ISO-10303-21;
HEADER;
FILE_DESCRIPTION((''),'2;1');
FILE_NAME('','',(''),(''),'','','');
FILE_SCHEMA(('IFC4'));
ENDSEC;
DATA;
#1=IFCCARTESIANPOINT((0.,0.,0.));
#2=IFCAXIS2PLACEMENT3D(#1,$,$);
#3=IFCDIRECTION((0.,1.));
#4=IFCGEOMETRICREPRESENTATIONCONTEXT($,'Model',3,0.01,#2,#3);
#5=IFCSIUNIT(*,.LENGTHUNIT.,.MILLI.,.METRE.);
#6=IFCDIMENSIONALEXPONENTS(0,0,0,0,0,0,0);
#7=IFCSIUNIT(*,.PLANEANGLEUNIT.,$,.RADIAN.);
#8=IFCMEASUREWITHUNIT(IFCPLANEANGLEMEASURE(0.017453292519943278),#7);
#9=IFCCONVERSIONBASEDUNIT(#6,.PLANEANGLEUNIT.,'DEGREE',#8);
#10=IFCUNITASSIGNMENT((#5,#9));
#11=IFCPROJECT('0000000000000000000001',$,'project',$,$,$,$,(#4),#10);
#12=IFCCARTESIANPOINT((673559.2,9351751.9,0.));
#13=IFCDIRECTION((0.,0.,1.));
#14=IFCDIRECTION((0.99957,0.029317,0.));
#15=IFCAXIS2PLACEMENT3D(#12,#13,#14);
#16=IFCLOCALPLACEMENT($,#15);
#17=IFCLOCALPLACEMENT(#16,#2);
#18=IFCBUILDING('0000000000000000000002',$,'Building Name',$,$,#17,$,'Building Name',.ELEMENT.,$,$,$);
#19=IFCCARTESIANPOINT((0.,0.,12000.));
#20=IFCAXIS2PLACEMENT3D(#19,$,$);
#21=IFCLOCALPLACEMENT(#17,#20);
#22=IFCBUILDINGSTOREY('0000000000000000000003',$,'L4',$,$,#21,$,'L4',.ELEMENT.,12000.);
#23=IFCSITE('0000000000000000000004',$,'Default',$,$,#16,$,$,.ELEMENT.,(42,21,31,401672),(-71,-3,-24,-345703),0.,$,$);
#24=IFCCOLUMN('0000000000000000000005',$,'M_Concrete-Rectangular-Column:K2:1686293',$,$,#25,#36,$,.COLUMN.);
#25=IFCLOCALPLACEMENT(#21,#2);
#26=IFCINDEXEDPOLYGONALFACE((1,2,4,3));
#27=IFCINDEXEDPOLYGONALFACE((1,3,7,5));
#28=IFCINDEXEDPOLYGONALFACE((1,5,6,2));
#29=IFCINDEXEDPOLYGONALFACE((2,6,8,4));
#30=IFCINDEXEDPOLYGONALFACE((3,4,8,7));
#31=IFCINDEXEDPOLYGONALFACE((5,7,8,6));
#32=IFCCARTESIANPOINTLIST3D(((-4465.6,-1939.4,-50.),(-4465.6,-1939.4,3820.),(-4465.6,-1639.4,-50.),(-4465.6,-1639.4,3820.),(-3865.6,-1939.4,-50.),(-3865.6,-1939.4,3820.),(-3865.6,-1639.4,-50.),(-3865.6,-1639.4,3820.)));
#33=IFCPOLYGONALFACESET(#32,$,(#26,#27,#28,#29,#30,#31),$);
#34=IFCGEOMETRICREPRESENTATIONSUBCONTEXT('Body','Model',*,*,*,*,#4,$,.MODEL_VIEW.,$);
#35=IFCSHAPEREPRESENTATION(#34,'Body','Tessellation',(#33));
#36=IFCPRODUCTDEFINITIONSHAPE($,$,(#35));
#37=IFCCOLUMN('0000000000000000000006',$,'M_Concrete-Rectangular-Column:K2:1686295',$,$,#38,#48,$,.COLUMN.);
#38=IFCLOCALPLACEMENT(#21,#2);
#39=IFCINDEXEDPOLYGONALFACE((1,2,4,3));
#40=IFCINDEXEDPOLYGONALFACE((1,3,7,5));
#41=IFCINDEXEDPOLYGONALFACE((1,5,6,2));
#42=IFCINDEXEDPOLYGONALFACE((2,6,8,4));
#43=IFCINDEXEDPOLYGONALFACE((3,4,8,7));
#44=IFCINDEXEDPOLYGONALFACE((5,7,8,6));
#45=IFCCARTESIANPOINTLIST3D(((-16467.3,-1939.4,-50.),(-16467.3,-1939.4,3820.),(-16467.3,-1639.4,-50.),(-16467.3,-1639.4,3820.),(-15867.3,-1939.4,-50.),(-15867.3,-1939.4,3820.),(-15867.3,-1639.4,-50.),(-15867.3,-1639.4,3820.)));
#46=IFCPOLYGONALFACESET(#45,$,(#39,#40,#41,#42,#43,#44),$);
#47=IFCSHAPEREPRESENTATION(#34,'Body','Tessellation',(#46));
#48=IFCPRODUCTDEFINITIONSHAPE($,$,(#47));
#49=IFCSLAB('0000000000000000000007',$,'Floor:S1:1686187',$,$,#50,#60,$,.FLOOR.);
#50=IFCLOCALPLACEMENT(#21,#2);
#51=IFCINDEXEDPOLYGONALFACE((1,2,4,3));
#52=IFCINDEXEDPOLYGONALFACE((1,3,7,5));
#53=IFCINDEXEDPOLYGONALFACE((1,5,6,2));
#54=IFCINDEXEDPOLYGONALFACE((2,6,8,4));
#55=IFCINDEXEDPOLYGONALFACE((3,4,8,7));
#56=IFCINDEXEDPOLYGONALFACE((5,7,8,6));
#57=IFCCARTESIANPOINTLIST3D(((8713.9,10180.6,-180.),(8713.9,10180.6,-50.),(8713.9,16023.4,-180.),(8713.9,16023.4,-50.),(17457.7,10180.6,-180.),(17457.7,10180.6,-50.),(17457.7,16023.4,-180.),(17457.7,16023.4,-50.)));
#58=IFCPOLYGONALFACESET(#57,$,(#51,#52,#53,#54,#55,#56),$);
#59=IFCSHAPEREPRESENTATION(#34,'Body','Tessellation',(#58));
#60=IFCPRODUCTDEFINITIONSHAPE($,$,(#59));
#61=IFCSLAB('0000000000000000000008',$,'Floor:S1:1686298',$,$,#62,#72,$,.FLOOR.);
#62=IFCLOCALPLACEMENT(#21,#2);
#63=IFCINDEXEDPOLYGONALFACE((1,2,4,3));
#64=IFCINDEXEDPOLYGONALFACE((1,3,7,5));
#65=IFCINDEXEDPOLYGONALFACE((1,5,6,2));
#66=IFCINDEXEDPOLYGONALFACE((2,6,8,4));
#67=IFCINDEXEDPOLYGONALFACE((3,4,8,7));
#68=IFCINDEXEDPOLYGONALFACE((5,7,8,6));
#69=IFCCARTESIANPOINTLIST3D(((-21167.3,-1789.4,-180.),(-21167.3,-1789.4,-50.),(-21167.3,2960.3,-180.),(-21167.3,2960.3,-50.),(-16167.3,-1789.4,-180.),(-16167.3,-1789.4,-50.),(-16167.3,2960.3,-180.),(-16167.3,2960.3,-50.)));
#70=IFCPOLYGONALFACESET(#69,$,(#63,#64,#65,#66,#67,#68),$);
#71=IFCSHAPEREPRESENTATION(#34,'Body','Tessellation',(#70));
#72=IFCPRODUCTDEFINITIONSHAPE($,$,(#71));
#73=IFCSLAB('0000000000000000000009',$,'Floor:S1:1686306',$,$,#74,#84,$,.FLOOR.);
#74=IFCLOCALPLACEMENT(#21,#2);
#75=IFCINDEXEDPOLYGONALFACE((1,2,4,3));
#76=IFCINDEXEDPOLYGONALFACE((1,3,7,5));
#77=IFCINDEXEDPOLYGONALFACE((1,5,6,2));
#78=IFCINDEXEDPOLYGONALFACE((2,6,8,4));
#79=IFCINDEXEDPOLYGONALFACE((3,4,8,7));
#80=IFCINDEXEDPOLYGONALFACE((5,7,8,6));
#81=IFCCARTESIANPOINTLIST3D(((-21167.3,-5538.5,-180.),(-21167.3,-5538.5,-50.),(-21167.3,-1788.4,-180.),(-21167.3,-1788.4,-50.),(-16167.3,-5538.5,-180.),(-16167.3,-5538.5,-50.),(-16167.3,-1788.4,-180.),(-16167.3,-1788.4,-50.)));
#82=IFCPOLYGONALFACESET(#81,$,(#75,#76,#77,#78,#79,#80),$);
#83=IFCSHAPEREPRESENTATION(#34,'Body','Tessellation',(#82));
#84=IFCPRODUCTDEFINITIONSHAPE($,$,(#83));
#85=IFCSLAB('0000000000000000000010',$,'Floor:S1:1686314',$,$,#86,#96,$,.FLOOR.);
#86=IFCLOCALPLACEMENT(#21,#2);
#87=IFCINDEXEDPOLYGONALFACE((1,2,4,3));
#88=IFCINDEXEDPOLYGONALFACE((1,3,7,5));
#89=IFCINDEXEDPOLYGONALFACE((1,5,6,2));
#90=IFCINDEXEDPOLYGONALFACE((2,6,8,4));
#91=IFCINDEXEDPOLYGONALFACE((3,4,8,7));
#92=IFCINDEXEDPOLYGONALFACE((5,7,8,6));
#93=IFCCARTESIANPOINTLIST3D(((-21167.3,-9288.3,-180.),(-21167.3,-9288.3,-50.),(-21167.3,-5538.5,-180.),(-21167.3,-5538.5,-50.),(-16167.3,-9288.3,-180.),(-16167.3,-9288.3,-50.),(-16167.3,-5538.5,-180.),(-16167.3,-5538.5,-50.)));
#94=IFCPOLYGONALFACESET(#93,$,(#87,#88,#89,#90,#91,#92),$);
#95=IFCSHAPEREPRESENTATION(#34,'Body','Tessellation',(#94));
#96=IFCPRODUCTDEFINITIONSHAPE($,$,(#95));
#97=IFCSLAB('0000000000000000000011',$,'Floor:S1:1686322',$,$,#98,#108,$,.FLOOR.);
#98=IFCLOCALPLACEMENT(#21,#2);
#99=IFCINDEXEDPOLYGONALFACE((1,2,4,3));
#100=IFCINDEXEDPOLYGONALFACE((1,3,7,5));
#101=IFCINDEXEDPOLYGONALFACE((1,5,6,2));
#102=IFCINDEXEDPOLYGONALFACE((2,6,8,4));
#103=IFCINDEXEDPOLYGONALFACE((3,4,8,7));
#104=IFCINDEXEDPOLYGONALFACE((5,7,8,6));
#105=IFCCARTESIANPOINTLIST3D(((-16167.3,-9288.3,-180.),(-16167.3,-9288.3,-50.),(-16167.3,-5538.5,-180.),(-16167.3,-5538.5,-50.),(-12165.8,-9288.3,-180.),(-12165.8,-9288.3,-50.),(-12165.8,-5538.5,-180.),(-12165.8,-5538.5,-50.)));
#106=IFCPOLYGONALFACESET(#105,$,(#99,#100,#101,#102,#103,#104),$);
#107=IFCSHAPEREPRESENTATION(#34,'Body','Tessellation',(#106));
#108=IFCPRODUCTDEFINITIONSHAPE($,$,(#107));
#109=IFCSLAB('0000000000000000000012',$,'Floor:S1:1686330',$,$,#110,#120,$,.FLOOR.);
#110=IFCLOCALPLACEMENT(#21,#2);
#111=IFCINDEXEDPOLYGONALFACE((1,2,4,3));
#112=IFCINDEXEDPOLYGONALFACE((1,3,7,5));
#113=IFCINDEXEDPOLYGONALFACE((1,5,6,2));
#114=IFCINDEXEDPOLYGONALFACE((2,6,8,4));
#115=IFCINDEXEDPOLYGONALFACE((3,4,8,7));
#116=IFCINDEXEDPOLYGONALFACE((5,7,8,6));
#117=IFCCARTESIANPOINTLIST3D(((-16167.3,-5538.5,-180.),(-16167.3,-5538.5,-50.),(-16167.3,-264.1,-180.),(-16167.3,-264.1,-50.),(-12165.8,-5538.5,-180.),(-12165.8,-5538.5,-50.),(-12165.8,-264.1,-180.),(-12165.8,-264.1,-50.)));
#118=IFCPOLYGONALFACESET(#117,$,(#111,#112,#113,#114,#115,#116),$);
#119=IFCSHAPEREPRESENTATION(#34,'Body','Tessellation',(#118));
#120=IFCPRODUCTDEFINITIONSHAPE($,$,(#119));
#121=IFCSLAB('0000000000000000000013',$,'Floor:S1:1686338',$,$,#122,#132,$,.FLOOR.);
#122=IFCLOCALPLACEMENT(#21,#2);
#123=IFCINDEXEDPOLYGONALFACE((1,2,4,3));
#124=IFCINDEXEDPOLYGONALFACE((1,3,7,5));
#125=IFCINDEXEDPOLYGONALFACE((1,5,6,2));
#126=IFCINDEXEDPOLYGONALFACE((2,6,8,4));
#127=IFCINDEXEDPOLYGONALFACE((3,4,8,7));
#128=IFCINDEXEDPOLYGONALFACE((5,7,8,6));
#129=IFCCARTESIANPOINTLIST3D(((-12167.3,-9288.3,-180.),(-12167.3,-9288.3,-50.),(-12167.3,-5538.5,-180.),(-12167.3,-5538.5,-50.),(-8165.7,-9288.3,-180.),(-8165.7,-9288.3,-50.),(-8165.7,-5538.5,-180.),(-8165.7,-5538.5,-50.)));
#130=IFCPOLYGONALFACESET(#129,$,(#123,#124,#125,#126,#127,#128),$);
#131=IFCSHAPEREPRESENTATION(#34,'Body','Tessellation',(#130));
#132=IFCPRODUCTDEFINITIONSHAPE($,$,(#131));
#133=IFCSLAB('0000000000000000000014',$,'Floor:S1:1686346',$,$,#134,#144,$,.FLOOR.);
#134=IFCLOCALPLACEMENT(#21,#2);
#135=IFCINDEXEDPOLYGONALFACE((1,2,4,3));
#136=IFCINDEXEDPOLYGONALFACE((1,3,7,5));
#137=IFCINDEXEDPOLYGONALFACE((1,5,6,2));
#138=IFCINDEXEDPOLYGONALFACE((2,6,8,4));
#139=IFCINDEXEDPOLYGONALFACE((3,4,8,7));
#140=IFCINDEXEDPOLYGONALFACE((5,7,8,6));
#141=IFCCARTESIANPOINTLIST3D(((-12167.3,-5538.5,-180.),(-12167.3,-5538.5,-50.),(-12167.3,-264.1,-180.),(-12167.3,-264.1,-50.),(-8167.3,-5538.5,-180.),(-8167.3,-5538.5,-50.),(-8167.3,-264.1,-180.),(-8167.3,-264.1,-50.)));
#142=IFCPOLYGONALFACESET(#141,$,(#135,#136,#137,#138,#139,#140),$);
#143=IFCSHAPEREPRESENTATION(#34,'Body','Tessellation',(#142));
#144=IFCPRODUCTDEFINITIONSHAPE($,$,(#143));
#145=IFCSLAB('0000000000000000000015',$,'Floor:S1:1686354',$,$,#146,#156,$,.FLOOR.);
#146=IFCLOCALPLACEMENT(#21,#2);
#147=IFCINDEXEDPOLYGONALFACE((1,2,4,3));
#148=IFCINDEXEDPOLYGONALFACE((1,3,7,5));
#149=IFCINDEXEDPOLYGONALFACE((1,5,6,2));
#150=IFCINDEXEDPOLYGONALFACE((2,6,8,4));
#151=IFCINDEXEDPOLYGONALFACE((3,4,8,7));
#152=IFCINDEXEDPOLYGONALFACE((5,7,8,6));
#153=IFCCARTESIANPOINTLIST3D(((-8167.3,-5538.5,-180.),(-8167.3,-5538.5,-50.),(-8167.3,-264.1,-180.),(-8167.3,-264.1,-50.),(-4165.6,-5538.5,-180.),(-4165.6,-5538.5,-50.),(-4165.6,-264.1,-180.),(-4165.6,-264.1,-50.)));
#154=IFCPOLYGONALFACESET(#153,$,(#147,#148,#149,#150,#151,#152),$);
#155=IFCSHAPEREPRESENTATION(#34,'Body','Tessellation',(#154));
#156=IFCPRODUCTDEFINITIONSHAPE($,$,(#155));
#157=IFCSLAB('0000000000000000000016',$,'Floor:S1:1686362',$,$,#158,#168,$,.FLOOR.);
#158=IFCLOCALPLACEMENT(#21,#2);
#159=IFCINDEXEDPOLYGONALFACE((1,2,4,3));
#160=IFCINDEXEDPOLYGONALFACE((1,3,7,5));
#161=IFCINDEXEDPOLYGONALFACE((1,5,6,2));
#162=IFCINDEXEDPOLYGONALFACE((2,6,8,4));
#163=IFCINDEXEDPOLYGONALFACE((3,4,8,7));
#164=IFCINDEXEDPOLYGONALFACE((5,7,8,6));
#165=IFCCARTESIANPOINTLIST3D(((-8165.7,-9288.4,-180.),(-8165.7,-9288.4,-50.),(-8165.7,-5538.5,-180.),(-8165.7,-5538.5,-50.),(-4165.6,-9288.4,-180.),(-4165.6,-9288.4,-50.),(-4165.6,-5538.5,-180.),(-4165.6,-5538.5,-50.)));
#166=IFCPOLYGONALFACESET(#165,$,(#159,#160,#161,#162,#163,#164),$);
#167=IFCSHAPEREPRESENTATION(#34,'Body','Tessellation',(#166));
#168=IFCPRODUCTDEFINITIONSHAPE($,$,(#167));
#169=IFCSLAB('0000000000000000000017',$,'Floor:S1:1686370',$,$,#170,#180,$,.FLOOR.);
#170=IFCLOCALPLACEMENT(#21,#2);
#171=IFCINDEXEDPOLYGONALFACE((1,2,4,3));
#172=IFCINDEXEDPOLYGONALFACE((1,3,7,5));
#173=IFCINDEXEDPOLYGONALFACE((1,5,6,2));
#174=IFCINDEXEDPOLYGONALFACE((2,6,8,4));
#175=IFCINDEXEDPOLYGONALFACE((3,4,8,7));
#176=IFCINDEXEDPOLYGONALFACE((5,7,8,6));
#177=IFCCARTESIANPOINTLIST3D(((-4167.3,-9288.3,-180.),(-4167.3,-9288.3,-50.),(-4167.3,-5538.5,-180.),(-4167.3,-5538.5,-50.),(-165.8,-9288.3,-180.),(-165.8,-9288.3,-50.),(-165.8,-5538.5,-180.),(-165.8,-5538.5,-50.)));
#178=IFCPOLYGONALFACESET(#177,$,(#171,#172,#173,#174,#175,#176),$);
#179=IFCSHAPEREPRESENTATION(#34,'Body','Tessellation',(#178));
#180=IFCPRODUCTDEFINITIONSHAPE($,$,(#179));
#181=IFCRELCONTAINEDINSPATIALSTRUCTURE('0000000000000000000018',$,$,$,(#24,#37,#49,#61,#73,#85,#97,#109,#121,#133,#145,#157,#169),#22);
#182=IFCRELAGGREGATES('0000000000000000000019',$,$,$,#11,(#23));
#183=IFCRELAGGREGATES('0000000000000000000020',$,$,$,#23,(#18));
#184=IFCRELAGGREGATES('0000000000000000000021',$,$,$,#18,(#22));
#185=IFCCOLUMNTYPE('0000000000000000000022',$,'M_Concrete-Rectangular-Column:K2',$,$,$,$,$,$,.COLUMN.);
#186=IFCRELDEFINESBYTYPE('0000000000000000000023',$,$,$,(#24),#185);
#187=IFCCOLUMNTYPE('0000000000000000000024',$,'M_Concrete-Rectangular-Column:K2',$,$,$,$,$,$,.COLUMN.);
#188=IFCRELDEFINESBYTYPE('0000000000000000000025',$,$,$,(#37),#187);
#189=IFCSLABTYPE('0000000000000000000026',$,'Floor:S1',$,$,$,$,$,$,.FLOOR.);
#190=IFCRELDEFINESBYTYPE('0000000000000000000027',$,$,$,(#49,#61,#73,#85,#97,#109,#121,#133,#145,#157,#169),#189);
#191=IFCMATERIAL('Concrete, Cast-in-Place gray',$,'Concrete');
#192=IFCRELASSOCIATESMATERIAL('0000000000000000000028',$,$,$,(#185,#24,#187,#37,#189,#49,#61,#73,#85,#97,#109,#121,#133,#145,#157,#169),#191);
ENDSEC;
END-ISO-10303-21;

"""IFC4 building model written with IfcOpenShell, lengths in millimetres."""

from ifc_helpers import new_model, entity, si_unit, converted_unit, direction, frame, origin, place, context, subcontext, project, spatial, indexed_curve, outline, extrude, source, transform, mapped, material, type_object, type_shapes, element, save


model = new_model("IFC4")

# Units and contexts
model_context = context("Model", 3, precision=0.01, world=origin(), true_north=direction((0.0, 1.0)))
body_context = subcontext(model_context, "Body", "Model", "MODEL_VIEW")
ifc_project = project(units=[si_unit("LENGTHUNIT", "METRE", prefix="MILLI"), converted_unit("PLANEANGLEUNIT", "DEGREE", entity("IfcPlaneAngleMeasure", 0.017453292519943278), si_unit("PLANEANGLEUNIT", "RADIAN"), dimensions=[0, 0, 0, 0, 0, 0, 0])], contexts=[model_context])

# Site, building, storey
site_placement = place(None, frame((673559.2, 9351751.9, 0.0), z_axis=(0.0, 0.0, 1.0), x_axis=(0.99957, 0.029317, 0.0)))
site = spatial("IfcSite", under=ifc_project, at=site_placement, Name="Default", CompositionType="ELEMENT", RefLatitude=(42, 21, 31, 401672), RefLongitude=(-71, -3, -24, -345703), RefElevation=0.0)
building_placement = place(site_placement, origin())
building = spatial("IfcBuilding", under=site, at=building_placement, Name="Building Name", LongName="Building Name", CompositionType="ELEMENT")
storey_placement = place(building_placement, frame((0.0, 0.0, 12000.0)))
storey = spatial("IfcBuildingStorey", under=building, at=storey_placement, Name="L4", LongName="L4", CompositionType="ELEMENT", Elevation=12000.0)

# Columns
ifc_material = material(Name="Concrete, Cast-in-Place gray", Category="Concrete")
column_type_1 = type_object("IfcColumnType", Name="M_Concrete-Rectangular-Column:K2", PredefinedType="COLUMN", material=ifc_material)
shared_shape_1 = source(origin(), body_context, "Body", "SweptSolid", [
    extrude(outline(indexed_curve([(-150.0, -300.0), (150.0, -300.0), (150.0, 300.0), (-150.0, 300.0), (-150.0, -300.0)], self_intersect=False)), frame((-4165.6, -1789.4, 11950.0), z_axis=(0.0, 0.0, 1.0), x_axis=(0.0, -1.0, 0.0)), (0.0, 0.0, 1.0), 3870.0),
])
type_shapes(column_type_1, [shared_shape_1])
column_1_placement = place(storey_placement, frame((0.0, 0.0, -12000.0)))
element("IfcColumn", 1, at=column_1_placement, inside=storey, type_object=column_type_1, material=ifc_material, Name="M_Concrete-Rectangular-Column:K2:1686293", PredefinedType="COLUMN", context=body_context, shape_type="MappedRepresentation", body=[
    mapped(shared_shape_1, transform((0.0, 0.0, 0.0), scale=1.0)),
])
column_type_2 = type_object("IfcColumnType", Name="M_Concrete-Rectangular-Column:K2", PredefinedType="COLUMN", material=ifc_material)
shared_shape_2 = source(origin(), body_context, "Body", "SweptSolid", [
    extrude(outline(indexed_curve([(-150.0, -300.0), (150.0, -300.0), (150.0, 300.0), (-150.0, 300.0), (-150.0, -300.0)], self_intersect=False)), frame((-16167.3, -1789.4, 11950.0), z_axis=(0.0, 0.0, 1.0), x_axis=(0.0, -1.0, 0.0)), (0.0, 0.0, 1.0), 3870.0),
])
type_shapes(column_type_2, [shared_shape_2])
column_2_placement = place(storey_placement, frame((0.0, 0.0, -12000.0)))
element("IfcColumn", 2, at=column_2_placement, inside=storey, type_object=column_type_2, material=ifc_material, Name="M_Concrete-Rectangular-Column:K2:1686295", PredefinedType="COLUMN", context=body_context, shape_type="MappedRepresentation", body=[
    mapped(shared_shape_2, transform((0.0, 0.0, 0.0), scale=1.0)),
])

# Slabs
slab_type_1 = type_object("IfcSlabType", Name="Floor:S1", PredefinedType="FLOOR", material=ifc_material)
slab_1_placement = place(storey_placement, origin())
element("IfcSlab", 3, at=slab_1_placement, inside=storey, type_object=slab_type_1, material=ifc_material, Name="Floor:S1:1686187", PredefinedType="FLOOR", context=body_context, shape_type="SweptSolid", body=[
    extrude(outline(indexed_curve([(-2921.4, -4371.9), (2921.4, -4371.9), (2921.4, 4371.9), (-2921.4, 4371.9), (-2921.4, -4371.9)], self_intersect=False)), frame((13085.8, 13102.0, -50.0), z_axis=(0.0, 0.0, -1.0), x_axis=(0.0, 1.0, 0.0)), (0.0, 0.0, 1.0), 130.0),
])
slab_2_placement = place(storey_placement, origin())
element("IfcSlab", 4, at=slab_2_placement, inside=storey, type_object=slab_type_1, material=ifc_material, Name="Floor:S1:1686298", PredefinedType="FLOOR", context=body_context, shape_type="SweptSolid", body=[
    extrude(outline(indexed_curve([(-2374.9, -2500.0), (2374.9, -2500.0), (2374.9, 2500.0), (-2374.9, 2500.0), (-2374.9, -2500.0)], self_intersect=False)), frame((-18667.3, 585.4, -50.0), z_axis=(0.0, 0.0, -1.0), x_axis=(0.0, 1.0, 0.0)), (0.0, 0.0, 1.0), 130.0),
])
slab_3_placement = place(storey_placement, origin())
element("IfcSlab", 5, at=slab_3_placement, inside=storey, type_object=slab_type_1, material=ifc_material, Name="Floor:S1:1686306", PredefinedType="FLOOR", context=body_context, shape_type="SweptSolid", body=[
    extrude(outline(indexed_curve([(-1875.1, -2500.0), (1875.1, -2500.0), (1875.1, 2500.0), (-1875.1, 2500.0), (-1875.1, -2500.0)], self_intersect=False)), frame((-18667.3, -3663.5, -50.0), z_axis=(0.0, 0.0, -1.0), x_axis=(0.0, 1.0, 0.0)), (0.0, 0.0, 1.0), 130.0),
])
slab_4_placement = place(storey_placement, origin())
element("IfcSlab", 6, at=slab_4_placement, inside=storey, type_object=slab_type_1, material=ifc_material, Name="Floor:S1:1686314", PredefinedType="FLOOR", context=body_context, shape_type="SweptSolid", body=[
    extrude(outline(indexed_curve([(-1874.9, -2500.0), (1874.9, -2500.0), (1874.9, 2500.0), (-1874.9, 2500.0), (-1874.9, -2500.0)], self_intersect=False)), frame((-18667.3, -7413.4, -50.0), z_axis=(0.0, 0.0, -1.0), x_axis=(0.0, 1.0, 0.0)), (0.0, 0.0, 1.0), 130.0),
])
slab_5_placement = place(storey_placement, origin())
element("IfcSlab", 7, at=slab_5_placement, inside=storey, type_object=slab_type_1, material=ifc_material, Name="Floor:S1:1686322", PredefinedType="FLOOR", context=body_context, shape_type="SweptSolid", body=[
    extrude(outline(indexed_curve([(-1874.9, -2000.8), (1874.9, -2000.8), (1874.9, 2000.8), (-1874.9, 2000.8), (-1874.9, -2000.8)], self_intersect=False)), frame((-14166.6, -7413.4, -50.0), z_axis=(0.0, 0.0, -1.0), x_axis=(0.0, 1.0, 0.0)), (0.0, 0.0, 1.0), 130.0),
])
slab_6_placement = place(storey_placement, origin())
element("IfcSlab", 8, at=slab_6_placement, inside=storey, type_object=slab_type_1, material=ifc_material, Name="Floor:S1:1686330", PredefinedType="FLOOR", context=body_context, shape_type="SweptSolid", body=[
    extrude(outline(indexed_curve([(-2637.2, -2000.8), (2637.2, -2000.8), (2637.2, 2000.8), (-2637.2, 2000.8), (-2637.2, -2000.8)], self_intersect=False)), frame((-14166.6, -2901.3, -50.0), z_axis=(0.0, 0.0, -1.0), x_axis=(0.0, 1.0, 0.0)), (0.0, 0.0, 1.0), 130.0),
])
slab_7_placement = place(storey_placement, origin())
element("IfcSlab", 9, at=slab_7_placement, inside=storey, type_object=slab_type_1, material=ifc_material, Name="Floor:S1:1686338", PredefinedType="FLOOR", context=body_context, shape_type="SweptSolid", body=[
    extrude(outline(indexed_curve([(-1874.9, -2000.8), (1874.9, -2000.8), (1874.9, 2000.8), (-1874.9, 2000.8), (-1874.9, -2000.8)], self_intersect=False)), frame((-10166.5, -7413.4, -50.0), z_axis=(0.0, 0.0, -1.0), x_axis=(0.0, 1.0, 0.0)), (0.0, 0.0, 1.0), 130.0),
])
slab_8_placement = place(storey_placement, origin())
element("IfcSlab", 10, at=slab_8_placement, inside=storey, type_object=slab_type_1, material=ifc_material, Name="Floor:S1:1686346", PredefinedType="FLOOR", context=body_context, shape_type="SweptSolid", body=[
    extrude(outline(indexed_curve([(-2637.2, -2000.0), (2637.2, -2000.0), (2637.2, 2000.0), (-2637.2, 2000.0), (-2637.2, -2000.0)], self_intersect=False)), frame((-10167.3, -2901.3, -50.0), z_axis=(0.0, 0.0, -1.0), x_axis=(0.0, 1.0, 0.0)), (0.0, 0.0, 1.0), 130.0),
])
slab_9_placement = place(storey_placement, origin())
element("IfcSlab", 11, at=slab_9_placement, inside=storey, type_object=slab_type_1, material=ifc_material, Name="Floor:S1:1686354", PredefinedType="FLOOR", context=body_context, shape_type="SweptSolid", body=[
    extrude(outline(indexed_curve([(-2637.2, -2000.9), (2637.2, -2000.9), (2637.2, 2000.9), (-2637.2, 2000.9), (-2637.2, -2000.9)], self_intersect=False)), frame((-6166.4, -2901.3, -50.0), z_axis=(0.0, 0.0, -1.0), x_axis=(0.0, 1.0, 0.0)), (0.0, 0.0, 1.0), 130.0),
])
slab_10_placement = place(storey_placement, origin())
element("IfcSlab", 12, at=slab_10_placement, inside=storey, type_object=slab_type_1, material=ifc_material, Name="Floor:S1:1686362", PredefinedType="FLOOR", context=body_context, shape_type="SweptSolid", body=[
    extrude(outline(indexed_curve([(-1874.9, -2000.1), (1874.9, -2000.1), (1874.9, 2000.1), (-1874.9, 2000.1), (-1874.9, -2000.1)], self_intersect=False)), frame((-6165.6, -7413.5, -50.0), z_axis=(0.0, 0.0, -1.0), x_axis=(0.0, 1.0, 0.0)), (0.0, 0.0, 1.0), 130.0),
])
slab_11_placement = place(storey_placement, origin())
element("IfcSlab", 13, at=slab_11_placement, inside=storey, type_object=slab_type_1, material=ifc_material, Name="Floor:S1:1686370", PredefinedType="FLOOR", context=body_context, shape_type="SweptSolid", body=[
    extrude(outline(indexed_curve([(-1874.9, -2000.8), (1874.9, -2000.8), (1874.9, 2000.8), (-1874.9, 2000.8), (-1874.9, -2000.8)], self_intersect=False)), frame((-2166.6, -7413.4, -50.0), z_axis=(0.0, 0.0, -1.0), x_axis=(0.0, 1.0, 0.0)), (0.0, 0.0, 1.0), 130.0),
])

save(model, "model.ifc")
